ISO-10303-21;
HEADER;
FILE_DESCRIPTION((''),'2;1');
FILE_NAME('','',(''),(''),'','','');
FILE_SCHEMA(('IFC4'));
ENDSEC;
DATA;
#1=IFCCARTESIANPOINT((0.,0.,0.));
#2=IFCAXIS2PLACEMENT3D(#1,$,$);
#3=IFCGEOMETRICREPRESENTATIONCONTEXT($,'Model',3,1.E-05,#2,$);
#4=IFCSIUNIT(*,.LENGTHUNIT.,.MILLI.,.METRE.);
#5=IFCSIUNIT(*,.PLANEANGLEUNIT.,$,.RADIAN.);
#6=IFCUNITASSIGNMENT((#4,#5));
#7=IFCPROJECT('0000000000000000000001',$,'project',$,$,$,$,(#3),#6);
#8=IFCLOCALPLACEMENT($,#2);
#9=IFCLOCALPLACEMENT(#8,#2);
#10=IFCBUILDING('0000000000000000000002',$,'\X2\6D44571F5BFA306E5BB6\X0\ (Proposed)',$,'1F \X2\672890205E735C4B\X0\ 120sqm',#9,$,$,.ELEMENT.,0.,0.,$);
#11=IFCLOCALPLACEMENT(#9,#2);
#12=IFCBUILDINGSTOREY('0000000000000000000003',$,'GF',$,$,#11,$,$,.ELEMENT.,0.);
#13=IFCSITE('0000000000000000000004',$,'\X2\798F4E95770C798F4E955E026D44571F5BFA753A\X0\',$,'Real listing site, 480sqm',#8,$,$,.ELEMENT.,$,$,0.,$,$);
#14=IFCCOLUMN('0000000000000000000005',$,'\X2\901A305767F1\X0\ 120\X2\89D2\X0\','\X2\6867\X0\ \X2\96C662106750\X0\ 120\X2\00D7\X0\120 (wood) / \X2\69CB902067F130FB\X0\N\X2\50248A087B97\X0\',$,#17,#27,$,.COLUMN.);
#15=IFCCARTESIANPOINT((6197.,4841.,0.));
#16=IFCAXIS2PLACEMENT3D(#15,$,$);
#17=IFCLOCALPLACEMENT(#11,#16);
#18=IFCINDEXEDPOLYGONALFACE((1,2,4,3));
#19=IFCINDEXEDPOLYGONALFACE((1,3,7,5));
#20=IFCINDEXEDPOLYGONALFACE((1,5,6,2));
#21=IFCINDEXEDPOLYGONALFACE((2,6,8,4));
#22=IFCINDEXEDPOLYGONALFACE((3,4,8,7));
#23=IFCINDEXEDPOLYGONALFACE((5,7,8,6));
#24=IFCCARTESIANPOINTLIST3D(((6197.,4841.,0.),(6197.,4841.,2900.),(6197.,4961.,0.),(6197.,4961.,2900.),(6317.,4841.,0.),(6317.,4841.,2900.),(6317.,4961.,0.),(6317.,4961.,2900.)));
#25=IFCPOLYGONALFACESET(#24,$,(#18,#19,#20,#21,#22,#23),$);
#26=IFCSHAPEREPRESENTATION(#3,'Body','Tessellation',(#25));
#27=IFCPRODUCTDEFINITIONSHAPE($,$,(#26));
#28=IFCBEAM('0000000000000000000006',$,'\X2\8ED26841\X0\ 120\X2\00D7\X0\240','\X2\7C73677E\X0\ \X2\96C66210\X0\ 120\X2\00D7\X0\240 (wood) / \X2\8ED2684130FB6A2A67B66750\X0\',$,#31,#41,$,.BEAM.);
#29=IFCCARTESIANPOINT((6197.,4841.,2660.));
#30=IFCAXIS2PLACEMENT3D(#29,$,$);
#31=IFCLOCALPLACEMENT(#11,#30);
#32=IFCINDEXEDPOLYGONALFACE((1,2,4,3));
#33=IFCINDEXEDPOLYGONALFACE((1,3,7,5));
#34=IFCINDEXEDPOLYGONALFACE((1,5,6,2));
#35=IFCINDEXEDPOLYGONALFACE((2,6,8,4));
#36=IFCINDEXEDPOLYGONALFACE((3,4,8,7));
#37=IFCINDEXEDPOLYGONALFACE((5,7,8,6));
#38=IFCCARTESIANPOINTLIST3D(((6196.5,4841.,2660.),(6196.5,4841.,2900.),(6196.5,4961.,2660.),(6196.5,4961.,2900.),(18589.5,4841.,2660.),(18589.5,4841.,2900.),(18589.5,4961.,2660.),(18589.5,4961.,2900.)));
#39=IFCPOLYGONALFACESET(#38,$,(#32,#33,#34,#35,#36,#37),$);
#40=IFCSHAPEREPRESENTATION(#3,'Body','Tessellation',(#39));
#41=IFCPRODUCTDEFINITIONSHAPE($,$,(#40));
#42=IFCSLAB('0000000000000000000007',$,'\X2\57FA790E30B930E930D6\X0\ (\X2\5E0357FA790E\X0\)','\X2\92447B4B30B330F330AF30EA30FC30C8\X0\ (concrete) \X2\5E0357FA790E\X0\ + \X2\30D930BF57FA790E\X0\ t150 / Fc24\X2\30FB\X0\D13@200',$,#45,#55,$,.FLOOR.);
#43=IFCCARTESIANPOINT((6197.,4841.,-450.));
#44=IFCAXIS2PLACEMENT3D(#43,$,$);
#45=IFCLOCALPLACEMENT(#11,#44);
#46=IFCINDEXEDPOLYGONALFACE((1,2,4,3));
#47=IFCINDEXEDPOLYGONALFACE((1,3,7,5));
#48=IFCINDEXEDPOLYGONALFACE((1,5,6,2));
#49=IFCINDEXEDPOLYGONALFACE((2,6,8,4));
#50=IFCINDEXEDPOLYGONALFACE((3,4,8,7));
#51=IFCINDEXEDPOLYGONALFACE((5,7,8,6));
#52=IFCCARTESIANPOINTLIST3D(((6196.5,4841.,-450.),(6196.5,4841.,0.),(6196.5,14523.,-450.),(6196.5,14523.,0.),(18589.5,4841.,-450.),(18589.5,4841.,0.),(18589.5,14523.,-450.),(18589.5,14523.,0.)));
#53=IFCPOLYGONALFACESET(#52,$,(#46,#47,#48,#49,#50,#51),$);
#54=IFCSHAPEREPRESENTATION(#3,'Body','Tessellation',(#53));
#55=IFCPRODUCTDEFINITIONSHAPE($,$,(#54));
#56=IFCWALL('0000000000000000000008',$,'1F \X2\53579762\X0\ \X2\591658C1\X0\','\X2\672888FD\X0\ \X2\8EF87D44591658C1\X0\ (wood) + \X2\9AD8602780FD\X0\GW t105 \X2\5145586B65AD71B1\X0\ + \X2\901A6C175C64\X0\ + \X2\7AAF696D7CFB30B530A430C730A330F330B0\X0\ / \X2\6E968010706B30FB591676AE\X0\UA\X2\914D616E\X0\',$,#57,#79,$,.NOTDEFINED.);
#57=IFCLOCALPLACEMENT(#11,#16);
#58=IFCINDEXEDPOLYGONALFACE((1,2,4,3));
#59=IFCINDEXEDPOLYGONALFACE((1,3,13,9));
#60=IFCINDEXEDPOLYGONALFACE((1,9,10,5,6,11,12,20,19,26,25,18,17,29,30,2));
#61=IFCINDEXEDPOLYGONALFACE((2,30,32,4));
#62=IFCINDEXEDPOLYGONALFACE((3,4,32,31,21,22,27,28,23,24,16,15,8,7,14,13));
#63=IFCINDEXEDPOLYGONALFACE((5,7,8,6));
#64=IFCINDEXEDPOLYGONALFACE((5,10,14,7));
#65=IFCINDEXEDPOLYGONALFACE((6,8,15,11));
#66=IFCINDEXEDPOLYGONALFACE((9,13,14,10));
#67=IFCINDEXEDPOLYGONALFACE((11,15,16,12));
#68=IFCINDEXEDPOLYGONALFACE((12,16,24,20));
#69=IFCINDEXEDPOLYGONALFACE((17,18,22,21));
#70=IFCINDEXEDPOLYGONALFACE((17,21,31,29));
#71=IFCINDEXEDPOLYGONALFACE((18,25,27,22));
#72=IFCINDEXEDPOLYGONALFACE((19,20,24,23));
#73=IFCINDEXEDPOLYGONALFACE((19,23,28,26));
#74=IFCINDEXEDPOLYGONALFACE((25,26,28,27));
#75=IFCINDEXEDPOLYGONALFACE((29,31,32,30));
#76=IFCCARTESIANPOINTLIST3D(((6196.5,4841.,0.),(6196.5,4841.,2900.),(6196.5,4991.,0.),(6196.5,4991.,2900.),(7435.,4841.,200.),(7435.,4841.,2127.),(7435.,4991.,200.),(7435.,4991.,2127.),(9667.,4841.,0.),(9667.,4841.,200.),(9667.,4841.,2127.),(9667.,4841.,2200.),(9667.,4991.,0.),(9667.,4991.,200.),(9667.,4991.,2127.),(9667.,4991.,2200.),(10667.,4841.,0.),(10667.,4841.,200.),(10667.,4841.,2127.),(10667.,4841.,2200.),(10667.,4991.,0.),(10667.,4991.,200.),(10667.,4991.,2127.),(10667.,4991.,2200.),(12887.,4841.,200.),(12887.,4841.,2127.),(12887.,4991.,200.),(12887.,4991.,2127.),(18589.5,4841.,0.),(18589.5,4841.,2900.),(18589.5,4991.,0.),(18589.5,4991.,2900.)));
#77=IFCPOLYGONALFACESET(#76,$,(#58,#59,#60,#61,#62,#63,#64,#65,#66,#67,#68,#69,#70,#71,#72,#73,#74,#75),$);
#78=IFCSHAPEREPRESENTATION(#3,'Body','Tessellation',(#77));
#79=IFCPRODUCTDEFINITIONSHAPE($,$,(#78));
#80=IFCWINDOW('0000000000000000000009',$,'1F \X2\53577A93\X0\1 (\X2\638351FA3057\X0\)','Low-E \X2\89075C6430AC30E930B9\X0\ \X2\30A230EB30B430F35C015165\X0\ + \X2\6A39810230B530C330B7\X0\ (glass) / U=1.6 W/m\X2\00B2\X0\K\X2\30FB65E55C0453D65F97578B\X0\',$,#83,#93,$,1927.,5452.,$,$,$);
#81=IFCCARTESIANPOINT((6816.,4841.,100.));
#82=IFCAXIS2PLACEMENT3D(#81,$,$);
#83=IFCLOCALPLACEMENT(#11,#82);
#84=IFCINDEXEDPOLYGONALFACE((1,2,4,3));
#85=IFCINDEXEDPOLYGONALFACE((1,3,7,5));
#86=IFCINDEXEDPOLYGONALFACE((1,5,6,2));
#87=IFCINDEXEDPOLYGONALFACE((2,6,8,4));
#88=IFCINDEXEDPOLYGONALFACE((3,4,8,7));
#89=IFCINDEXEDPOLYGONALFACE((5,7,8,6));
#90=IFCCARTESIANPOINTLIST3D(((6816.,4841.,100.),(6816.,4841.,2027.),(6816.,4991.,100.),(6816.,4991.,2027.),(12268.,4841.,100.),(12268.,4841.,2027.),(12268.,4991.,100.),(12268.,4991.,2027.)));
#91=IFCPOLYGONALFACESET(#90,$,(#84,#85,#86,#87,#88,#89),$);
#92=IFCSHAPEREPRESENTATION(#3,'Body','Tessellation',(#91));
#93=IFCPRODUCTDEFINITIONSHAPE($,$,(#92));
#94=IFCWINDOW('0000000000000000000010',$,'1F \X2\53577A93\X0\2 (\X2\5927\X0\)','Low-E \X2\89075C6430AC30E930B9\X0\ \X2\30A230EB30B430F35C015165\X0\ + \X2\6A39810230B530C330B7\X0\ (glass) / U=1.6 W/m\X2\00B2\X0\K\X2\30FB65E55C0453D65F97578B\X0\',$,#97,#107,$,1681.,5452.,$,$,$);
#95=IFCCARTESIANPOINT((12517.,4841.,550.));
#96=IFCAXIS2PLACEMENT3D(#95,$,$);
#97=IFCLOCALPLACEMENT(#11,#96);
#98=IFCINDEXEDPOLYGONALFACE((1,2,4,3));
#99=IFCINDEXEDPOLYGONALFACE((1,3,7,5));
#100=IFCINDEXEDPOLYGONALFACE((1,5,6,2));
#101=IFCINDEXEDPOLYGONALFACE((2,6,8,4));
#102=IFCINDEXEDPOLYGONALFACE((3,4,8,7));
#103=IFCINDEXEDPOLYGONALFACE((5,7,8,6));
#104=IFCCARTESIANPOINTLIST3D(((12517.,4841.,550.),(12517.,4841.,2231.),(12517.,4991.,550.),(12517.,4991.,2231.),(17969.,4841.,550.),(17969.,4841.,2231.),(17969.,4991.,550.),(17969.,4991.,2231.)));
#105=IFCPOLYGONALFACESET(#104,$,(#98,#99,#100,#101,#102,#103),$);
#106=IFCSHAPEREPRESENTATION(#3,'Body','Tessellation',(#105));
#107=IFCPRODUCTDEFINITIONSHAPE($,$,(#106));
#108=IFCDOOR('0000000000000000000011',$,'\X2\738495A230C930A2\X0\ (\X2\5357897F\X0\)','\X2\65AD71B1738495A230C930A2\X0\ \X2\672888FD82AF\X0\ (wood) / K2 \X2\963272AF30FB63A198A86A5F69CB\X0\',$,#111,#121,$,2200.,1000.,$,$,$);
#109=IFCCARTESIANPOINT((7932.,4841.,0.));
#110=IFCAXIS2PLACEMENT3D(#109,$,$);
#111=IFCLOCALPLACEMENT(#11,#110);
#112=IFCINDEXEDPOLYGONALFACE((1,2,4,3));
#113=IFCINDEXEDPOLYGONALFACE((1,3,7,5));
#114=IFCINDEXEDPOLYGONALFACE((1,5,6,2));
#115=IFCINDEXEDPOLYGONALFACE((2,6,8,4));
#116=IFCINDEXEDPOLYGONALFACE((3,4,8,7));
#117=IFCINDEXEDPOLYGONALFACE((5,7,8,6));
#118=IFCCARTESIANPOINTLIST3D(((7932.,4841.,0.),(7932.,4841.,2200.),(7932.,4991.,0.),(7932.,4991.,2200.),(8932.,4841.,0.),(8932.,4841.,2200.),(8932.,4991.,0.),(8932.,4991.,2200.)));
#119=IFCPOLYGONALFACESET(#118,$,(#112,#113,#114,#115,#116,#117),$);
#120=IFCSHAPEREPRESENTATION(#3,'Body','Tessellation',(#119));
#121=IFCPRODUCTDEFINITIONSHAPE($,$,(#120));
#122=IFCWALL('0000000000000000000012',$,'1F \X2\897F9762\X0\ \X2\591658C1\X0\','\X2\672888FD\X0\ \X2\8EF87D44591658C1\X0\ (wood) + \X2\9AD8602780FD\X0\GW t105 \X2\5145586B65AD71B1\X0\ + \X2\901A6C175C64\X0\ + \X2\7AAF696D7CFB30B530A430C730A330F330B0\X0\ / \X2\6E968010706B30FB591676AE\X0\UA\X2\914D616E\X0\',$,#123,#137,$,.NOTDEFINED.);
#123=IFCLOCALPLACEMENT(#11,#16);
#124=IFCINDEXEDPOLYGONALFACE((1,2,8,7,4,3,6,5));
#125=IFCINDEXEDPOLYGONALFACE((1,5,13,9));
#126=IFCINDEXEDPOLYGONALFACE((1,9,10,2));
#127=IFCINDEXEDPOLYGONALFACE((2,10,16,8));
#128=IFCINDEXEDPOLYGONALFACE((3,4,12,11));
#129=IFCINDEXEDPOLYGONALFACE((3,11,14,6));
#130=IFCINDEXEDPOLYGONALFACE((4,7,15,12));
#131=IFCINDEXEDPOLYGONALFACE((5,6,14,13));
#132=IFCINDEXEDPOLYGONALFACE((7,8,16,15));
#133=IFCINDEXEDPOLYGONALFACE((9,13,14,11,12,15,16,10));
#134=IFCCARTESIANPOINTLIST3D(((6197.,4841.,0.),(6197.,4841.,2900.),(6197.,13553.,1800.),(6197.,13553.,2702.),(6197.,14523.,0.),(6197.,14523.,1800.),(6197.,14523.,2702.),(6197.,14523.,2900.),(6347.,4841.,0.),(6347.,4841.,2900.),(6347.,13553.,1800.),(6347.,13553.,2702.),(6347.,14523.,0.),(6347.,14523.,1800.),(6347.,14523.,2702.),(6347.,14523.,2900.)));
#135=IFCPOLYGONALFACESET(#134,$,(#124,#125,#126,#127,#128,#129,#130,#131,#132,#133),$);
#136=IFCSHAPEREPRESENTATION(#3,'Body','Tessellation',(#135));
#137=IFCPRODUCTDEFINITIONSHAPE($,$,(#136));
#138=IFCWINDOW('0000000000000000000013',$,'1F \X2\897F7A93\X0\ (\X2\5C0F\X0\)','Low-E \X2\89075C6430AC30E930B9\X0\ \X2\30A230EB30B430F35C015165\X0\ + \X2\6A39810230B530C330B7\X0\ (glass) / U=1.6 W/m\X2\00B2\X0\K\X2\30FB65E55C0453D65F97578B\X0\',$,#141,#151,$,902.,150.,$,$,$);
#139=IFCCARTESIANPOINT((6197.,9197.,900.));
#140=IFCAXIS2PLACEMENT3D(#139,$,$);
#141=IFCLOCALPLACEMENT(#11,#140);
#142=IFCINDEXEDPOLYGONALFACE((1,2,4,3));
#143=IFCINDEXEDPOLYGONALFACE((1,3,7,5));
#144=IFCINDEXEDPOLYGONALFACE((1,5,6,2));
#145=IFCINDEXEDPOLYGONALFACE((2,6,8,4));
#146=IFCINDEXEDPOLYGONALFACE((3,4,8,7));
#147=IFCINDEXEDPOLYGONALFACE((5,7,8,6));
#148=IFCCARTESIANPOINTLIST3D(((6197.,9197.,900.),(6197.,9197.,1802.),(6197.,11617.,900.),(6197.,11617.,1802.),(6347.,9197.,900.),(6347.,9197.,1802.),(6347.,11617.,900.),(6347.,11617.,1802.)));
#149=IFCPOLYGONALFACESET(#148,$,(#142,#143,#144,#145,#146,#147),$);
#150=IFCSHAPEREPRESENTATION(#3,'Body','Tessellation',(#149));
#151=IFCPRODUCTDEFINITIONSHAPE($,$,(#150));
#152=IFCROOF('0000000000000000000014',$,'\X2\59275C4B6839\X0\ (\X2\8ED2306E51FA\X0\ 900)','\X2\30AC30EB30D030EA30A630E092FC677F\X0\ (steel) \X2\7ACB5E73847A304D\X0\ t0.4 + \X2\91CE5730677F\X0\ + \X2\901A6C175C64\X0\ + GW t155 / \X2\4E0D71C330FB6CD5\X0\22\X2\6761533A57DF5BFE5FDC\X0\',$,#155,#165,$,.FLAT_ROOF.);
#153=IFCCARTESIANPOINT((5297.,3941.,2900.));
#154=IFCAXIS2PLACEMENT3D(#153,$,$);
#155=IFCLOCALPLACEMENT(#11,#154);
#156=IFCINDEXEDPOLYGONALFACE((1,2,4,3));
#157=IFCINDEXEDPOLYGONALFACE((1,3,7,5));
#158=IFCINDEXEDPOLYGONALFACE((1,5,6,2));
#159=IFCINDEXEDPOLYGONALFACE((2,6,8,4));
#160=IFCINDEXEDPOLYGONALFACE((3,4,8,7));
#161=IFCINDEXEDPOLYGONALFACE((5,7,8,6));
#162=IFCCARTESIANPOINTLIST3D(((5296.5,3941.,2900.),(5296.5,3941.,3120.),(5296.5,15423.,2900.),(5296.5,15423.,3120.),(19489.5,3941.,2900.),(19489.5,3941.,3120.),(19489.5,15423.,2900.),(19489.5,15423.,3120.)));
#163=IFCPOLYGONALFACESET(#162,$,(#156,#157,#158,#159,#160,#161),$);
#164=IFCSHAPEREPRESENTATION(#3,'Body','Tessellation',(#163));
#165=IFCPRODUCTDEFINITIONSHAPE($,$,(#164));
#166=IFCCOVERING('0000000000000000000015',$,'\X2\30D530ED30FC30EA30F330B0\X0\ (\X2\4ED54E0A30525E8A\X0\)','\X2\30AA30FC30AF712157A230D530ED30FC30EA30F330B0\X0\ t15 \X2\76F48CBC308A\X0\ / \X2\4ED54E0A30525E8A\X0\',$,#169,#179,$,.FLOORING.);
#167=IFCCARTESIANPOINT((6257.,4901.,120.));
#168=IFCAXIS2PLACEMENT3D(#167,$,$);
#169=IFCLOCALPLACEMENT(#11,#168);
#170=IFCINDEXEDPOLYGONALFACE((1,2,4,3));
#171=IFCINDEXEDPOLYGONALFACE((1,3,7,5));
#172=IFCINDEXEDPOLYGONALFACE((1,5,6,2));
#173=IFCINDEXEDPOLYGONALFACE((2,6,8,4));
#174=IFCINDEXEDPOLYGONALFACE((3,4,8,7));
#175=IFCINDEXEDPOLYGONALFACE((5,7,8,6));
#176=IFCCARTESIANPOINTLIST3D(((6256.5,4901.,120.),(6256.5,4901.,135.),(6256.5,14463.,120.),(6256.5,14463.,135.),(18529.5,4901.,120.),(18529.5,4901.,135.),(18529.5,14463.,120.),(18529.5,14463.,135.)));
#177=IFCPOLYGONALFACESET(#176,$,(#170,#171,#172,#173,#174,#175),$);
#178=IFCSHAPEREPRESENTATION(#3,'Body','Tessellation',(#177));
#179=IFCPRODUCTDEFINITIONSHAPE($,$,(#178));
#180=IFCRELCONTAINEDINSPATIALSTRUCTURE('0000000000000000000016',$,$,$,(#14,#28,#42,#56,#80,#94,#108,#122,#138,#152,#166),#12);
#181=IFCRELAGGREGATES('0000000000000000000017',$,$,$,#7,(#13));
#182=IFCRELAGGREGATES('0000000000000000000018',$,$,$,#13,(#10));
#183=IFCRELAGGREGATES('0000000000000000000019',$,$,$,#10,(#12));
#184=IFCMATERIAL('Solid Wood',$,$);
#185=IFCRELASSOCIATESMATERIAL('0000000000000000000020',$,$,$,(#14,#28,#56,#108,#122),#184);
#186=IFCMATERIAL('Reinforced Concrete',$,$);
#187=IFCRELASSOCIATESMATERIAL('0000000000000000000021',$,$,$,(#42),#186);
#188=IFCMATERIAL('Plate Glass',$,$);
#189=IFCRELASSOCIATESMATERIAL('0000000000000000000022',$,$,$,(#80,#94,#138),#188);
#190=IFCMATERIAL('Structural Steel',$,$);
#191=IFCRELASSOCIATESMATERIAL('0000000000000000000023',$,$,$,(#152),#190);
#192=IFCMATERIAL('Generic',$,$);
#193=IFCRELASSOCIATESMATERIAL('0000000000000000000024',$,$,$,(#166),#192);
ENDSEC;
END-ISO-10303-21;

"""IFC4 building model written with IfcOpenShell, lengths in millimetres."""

from ifc_helpers import new_model, si_unit, frame, frame_2d, origin, place, context, project, spatial, rectangle, extrude, material, element, fill, save


model = new_model("IFC4")

# Units and contexts
model_context = context("Model", 3, precision=1e-05, world=origin())
ifc_project = project(units=[si_unit("LENGTHUNIT", "METRE", prefix="MILLI"), si_unit("PLANEANGLEUNIT", "RADIAN")], contexts=[model_context])

# Site, building, storey
site_placement = place(None, origin())
site = spatial("IfcSite", under=ifc_project, at=site_placement, Name="福井県福井市浄土寺町", ObjectType="Real listing site, 480sqm", CompositionType="ELEMENT", RefElevation=0.0)
building_placement = place(site_placement, origin())
building = spatial("IfcBuilding", under=site, at=building_placement, Name="浄土寺の家 (Proposed)", ObjectType="1F 木造平屋 120sqm", CompositionType="ELEMENT", ElevationOfRefHeight=0.0, ElevationOfTerrain=0.0)
storey_placement = place(building_placement, origin())
storey = spatial("IfcBuildingStorey", under=building, at=storey_placement, Name="GF", CompositionType="ELEMENT", Elevation=0.0)

# Column
ifc_material_1 = material(Name="Solid Wood")
column_1_placement = place(storey_placement, frame((6197.0, 4841.0, 0.0)))
element("IfcColumn", 1, at=column_1_placement, inside=storey, material=ifc_material_1, Name="通し柱 120角", Description="桧 集成材 120×120 (wood) / 構造柱・N値計算", PredefinedType="COLUMN", context=model_context, shape_type="SweptSolid", body=[
    extrude(rectangle(XDim=120.0, YDim=120.0, at=frame_2d((60.0, 60.0))), frame((6197.0, 4841.0, 0.0)), (0.0, 0.0, 1.0), 2900.0),
])

# Beam
beam_1_placement = place(storey_placement, frame((6197.0, 4841.0, 2660.0)))
element("IfcBeam", 2, at=beam_1_placement, inside=storey, material=ifc_material_1, Name="軒桁 120×240", Description="米松 集成 120×240 (wood) / 軒桁・横架材", PredefinedType="BEAM", context=model_context, shape_type="SweptSolid", body=[
    extrude(rectangle(XDim=12393.0, YDim=120.0, at=frame_2d((6196.0, 60.0))), frame((6197.0, 4841.0, 2660.0)), (0.0, 0.0, 1.0), 240.0),
])

# Slab
ifc_material_2 = material(Name="Reinforced Concrete")
slab_1_placement = place(storey_placement, frame((6197.0, 4841.0, -450.0)))
element("IfcSlab", 3, at=slab_1_placement, inside=storey, material=ifc_material_2, Name="基礎スラブ (布基礎)", Description="鉄筋コンクリート (concrete) 布基礎 + ベタ基礎 t150 / Fc24・D13@200", PredefinedType="FLOOR", context=model_context, shape_type="SweptSolid", body=[
    extrude(rectangle(XDim=12393.0, YDim=9682.0, at=frame_2d((6196.0, 4841.0))), frame((6197.0, 4841.0, -450.0)), (0.0, 0.0, 1.0), 450.0),
])

# Wall, openings, windows, door
wall_1_placement = place(storey_placement, frame((6197.0, 4841.0, 0.0)))
wall_1 = element("IfcWall", 4, at=wall_1_placement, inside=storey, material=ifc_material_1, Name="1F 南面 外壁", Description="木製 軸組外壁 (wood) + 高性能GW t105 充填断熱 + 通気層 + 窯業系サイディング / 準耐火・外皮UA配慮", PredefinedType="NOTDEFINED", context=model_context, shape_type="SweptSolid", body=[
    extrude(rectangle(XDim=12393.0, YDim=150.0, at=frame_2d((6196.0, 75.0))), frame((6197.0, 4841.0, 0.0)), (0.0, 0.0, 1.0), 2900.0),
])
opening_1_placement = place(storey_placement, frame((6816.0, 4841.0, 100.0)))
opening_1 = element("IfcOpeningElement", 5, at=opening_1_placement, cuts=wall_1, PredefinedType="NOTDEFINED", context=model_context, shape_type="SweptSolid", body=[
    extrude(rectangle(XDim=5452.0, YDim=150.0, at=frame_2d((2726.0, 75.0))), frame((6816.0, 4841.0, 100.0)), (0.0, 0.0, 1.0), 1927.0),
])
opening_2_placement = place(storey_placement, frame((12517.0, 4841.0, 550.0)))
opening_2 = element("IfcOpeningElement", 6, at=opening_2_placement, cuts=wall_1, PredefinedType="NOTDEFINED", context=model_context, shape_type="SweptSolid", body=[
    extrude(rectangle(XDim=5452.0, YDim=150.0, at=frame_2d((2726.0, 75.0))), frame((12517.0, 4841.0, 550.0)), (0.0, 0.0, 1.0), 1681.0),
])
opening_3_placement = place(storey_placement, frame((7932.0, 4841.0, 0.0)))
opening_3 = element("IfcOpeningElement", 7, at=opening_3_placement, cuts=wall_1, PredefinedType="NOTDEFINED", context=model_context, shape_type="SweptSolid", body=[
    extrude(rectangle(XDim=1000.0, YDim=150.0, at=frame_2d((500.0, 75.0))), frame((7932.0, 4841.0, 0.0)), (0.0, 0.0, 1.0), 2200.0),
])
ifc_material_3 = material(Name="Plate Glass")
window_1_placement = place(storey_placement, frame((6816.0, 4841.0, 100.0)))
window_1 = element("IfcWindow", 8, at=window_1_placement, inside=storey, material=ifc_material_3, Name="1F 南窓1 (掃出し)", Description="Low-E 複層ガラス アルゴン封入 + 樹脂サッシ (glass) / U=1.6 W/m²K・日射取得型", OverallHeight=1927.0, OverallWidth=5452.0, context=model_context, shape_type="SweptSolid", body=[
    extrude(rectangle(XDim=5452.0, YDim=150.0, at=frame_2d((2726.0, 75.0))), frame((6816.0, 4841.0, 100.0)), (0.0, 0.0, 1.0), 1927.0),
])
fill(opening_1, window_1)
window_2_placement = place(storey_placement, frame((12517.0, 4841.0, 550.0)))
window_2 = element("IfcWindow", 9, at=window_2_placement, inside=storey, material=ifc_material_3, Name="1F 南窓2 (大)", Description="Low-E 複層ガラス アルゴン封入 + 樹脂サッシ (glass) / U=1.6 W/m²K・日射取得型", OverallHeight=1681.0, OverallWidth=5452.0, context=model_context, shape_type="SweptSolid", body=[
    extrude(rectangle(XDim=5452.0, YDim=150.0, at=frame_2d((2726.0, 75.0))), frame((12517.0, 4841.0, 550.0)), (0.0, 0.0, 1.0), 1681.0),
])
fill(opening_2, window_2)
door_placement = place(storey_placement, frame((7932.0, 4841.0, 0.0)))
door = element("IfcDoor", 10, at=door_placement, inside=storey, material=ifc_material_1, Name="玄関ドア (南西)", Description="断熱玄関ドア 木製芯 (wood) / K2 防犯・採風機構", OverallHeight=2200.0, OverallWidth=1000.0, context=model_context, shape_type="SweptSolid", body=[
    extrude(rectangle(XDim=1000.0, YDim=150.0, at=frame_2d((500.0, 75.0))), frame((7932.0, 4841.0, 0.0)), (0.0, 0.0, 1.0), 2200.0),
])
fill(opening_3, door)

# Wall, opening, window
wall_2_placement = place(storey_placement, frame((6197.0, 4841.0, 0.0)))
wall_2 = element("IfcWall", 11, at=wall_2_placement, inside=storey, material=ifc_material_1, Name="1F 西面 外壁", Description="木製 軸組外壁 (wood) + 高性能GW t105 充填断熱 + 通気層 + 窯業系サイディング / 準耐火・外皮UA配慮", PredefinedType="NOTDEFINED", context=model_context, shape_type="SweptSolid", body=[
    extrude(rectangle(XDim=150.0, YDim=9682.0, at=frame_2d((75.0, 4841.0))), frame((6197.0, 4841.0, 0.0)), (0.0, 0.0, 1.0), 2900.0),
])
opening_4_placement = place(storey_placement, frame((6197.0, 9197.0, 900.0)))
opening_4 = element("IfcOpeningElement", 12, at=opening_4_placement, cuts=wall_2, PredefinedType="NOTDEFINED", context=model_context, shape_type="SweptSolid", body=[
    extrude(rectangle(XDim=150.0, YDim=2420.0, at=frame_2d((75.0, 1210.0))), frame((6197.0, 9197.0, 900.0)), (0.0, 0.0, 1.0), 902.0),
])
window_3_placement = place(storey_placement, frame((6197.0, 9197.0, 900.0)))
window_3 = element("IfcWindow", 13, at=window_3_placement, inside=storey, material=ifc_material_3, Name="1F 西窓 (小)", Description="Low-E 複層ガラス アルゴン封入 + 樹脂サッシ (glass) / U=1.6 W/m²K・日射取得型", OverallHeight=902.0, OverallWidth=150.0, context=model_context, shape_type="SweptSolid", body=[
    extrude(rectangle(XDim=150.0, YDim=2420.0, at=frame_2d((75.0, 1210.0))), frame((6197.0, 9197.0, 900.0)), (0.0, 0.0, 1.0), 902.0),
])
fill(opening_4, window_3)

# Roof
ifc_material_4 = material(Name="Structural Steel")
roof_placement = place(storey_placement, frame((5297.0, 3941.0, 2900.0)))
element("IfcRoof", 14, at=roof_placement, inside=storey, material=ifc_material_4, Name="大屋根 (軒の出 900)", Description="ガルバリウム鋼板 (steel) 立平葺き t0.4 + 野地板 + 通気層 + GW t155 / 不燃・法22条区域対応", PredefinedType="FLAT_ROOF", context=model_context, shape_type="SweptSolid", body=[
    extrude(rectangle(XDim=14193.0, YDim=11482.0, at=frame_2d((7096.0, 5741.0))), frame((5297.0, 3941.0, 2900.0)), (0.0, 0.0, 1.0), 220.0),
])

# Covering
ifc_material_5 = material(Name="Generic")
covering_1_placement = place(storey_placement, frame((6257.0, 4901.0, 120.0)))
element("IfcCovering", 15, at=covering_1_placement, inside=storey, material=ifc_material_5, Name="フローリング (仕上げ床)", Description="オーク無垢フローリング t15 直貼り / 仕上げ床", PredefinedType="FLOORING", context=model_context, shape_type="SweptSolid", body=[
    extrude(rectangle(XDim=12273.0, YDim=9562.0, at=frame_2d((6136.0, 4781.0))), frame((6257.0, 4901.0, 120.0)), (0.0, 0.0, 1.0), 15.0),
])

save(model, "model.ifc")
